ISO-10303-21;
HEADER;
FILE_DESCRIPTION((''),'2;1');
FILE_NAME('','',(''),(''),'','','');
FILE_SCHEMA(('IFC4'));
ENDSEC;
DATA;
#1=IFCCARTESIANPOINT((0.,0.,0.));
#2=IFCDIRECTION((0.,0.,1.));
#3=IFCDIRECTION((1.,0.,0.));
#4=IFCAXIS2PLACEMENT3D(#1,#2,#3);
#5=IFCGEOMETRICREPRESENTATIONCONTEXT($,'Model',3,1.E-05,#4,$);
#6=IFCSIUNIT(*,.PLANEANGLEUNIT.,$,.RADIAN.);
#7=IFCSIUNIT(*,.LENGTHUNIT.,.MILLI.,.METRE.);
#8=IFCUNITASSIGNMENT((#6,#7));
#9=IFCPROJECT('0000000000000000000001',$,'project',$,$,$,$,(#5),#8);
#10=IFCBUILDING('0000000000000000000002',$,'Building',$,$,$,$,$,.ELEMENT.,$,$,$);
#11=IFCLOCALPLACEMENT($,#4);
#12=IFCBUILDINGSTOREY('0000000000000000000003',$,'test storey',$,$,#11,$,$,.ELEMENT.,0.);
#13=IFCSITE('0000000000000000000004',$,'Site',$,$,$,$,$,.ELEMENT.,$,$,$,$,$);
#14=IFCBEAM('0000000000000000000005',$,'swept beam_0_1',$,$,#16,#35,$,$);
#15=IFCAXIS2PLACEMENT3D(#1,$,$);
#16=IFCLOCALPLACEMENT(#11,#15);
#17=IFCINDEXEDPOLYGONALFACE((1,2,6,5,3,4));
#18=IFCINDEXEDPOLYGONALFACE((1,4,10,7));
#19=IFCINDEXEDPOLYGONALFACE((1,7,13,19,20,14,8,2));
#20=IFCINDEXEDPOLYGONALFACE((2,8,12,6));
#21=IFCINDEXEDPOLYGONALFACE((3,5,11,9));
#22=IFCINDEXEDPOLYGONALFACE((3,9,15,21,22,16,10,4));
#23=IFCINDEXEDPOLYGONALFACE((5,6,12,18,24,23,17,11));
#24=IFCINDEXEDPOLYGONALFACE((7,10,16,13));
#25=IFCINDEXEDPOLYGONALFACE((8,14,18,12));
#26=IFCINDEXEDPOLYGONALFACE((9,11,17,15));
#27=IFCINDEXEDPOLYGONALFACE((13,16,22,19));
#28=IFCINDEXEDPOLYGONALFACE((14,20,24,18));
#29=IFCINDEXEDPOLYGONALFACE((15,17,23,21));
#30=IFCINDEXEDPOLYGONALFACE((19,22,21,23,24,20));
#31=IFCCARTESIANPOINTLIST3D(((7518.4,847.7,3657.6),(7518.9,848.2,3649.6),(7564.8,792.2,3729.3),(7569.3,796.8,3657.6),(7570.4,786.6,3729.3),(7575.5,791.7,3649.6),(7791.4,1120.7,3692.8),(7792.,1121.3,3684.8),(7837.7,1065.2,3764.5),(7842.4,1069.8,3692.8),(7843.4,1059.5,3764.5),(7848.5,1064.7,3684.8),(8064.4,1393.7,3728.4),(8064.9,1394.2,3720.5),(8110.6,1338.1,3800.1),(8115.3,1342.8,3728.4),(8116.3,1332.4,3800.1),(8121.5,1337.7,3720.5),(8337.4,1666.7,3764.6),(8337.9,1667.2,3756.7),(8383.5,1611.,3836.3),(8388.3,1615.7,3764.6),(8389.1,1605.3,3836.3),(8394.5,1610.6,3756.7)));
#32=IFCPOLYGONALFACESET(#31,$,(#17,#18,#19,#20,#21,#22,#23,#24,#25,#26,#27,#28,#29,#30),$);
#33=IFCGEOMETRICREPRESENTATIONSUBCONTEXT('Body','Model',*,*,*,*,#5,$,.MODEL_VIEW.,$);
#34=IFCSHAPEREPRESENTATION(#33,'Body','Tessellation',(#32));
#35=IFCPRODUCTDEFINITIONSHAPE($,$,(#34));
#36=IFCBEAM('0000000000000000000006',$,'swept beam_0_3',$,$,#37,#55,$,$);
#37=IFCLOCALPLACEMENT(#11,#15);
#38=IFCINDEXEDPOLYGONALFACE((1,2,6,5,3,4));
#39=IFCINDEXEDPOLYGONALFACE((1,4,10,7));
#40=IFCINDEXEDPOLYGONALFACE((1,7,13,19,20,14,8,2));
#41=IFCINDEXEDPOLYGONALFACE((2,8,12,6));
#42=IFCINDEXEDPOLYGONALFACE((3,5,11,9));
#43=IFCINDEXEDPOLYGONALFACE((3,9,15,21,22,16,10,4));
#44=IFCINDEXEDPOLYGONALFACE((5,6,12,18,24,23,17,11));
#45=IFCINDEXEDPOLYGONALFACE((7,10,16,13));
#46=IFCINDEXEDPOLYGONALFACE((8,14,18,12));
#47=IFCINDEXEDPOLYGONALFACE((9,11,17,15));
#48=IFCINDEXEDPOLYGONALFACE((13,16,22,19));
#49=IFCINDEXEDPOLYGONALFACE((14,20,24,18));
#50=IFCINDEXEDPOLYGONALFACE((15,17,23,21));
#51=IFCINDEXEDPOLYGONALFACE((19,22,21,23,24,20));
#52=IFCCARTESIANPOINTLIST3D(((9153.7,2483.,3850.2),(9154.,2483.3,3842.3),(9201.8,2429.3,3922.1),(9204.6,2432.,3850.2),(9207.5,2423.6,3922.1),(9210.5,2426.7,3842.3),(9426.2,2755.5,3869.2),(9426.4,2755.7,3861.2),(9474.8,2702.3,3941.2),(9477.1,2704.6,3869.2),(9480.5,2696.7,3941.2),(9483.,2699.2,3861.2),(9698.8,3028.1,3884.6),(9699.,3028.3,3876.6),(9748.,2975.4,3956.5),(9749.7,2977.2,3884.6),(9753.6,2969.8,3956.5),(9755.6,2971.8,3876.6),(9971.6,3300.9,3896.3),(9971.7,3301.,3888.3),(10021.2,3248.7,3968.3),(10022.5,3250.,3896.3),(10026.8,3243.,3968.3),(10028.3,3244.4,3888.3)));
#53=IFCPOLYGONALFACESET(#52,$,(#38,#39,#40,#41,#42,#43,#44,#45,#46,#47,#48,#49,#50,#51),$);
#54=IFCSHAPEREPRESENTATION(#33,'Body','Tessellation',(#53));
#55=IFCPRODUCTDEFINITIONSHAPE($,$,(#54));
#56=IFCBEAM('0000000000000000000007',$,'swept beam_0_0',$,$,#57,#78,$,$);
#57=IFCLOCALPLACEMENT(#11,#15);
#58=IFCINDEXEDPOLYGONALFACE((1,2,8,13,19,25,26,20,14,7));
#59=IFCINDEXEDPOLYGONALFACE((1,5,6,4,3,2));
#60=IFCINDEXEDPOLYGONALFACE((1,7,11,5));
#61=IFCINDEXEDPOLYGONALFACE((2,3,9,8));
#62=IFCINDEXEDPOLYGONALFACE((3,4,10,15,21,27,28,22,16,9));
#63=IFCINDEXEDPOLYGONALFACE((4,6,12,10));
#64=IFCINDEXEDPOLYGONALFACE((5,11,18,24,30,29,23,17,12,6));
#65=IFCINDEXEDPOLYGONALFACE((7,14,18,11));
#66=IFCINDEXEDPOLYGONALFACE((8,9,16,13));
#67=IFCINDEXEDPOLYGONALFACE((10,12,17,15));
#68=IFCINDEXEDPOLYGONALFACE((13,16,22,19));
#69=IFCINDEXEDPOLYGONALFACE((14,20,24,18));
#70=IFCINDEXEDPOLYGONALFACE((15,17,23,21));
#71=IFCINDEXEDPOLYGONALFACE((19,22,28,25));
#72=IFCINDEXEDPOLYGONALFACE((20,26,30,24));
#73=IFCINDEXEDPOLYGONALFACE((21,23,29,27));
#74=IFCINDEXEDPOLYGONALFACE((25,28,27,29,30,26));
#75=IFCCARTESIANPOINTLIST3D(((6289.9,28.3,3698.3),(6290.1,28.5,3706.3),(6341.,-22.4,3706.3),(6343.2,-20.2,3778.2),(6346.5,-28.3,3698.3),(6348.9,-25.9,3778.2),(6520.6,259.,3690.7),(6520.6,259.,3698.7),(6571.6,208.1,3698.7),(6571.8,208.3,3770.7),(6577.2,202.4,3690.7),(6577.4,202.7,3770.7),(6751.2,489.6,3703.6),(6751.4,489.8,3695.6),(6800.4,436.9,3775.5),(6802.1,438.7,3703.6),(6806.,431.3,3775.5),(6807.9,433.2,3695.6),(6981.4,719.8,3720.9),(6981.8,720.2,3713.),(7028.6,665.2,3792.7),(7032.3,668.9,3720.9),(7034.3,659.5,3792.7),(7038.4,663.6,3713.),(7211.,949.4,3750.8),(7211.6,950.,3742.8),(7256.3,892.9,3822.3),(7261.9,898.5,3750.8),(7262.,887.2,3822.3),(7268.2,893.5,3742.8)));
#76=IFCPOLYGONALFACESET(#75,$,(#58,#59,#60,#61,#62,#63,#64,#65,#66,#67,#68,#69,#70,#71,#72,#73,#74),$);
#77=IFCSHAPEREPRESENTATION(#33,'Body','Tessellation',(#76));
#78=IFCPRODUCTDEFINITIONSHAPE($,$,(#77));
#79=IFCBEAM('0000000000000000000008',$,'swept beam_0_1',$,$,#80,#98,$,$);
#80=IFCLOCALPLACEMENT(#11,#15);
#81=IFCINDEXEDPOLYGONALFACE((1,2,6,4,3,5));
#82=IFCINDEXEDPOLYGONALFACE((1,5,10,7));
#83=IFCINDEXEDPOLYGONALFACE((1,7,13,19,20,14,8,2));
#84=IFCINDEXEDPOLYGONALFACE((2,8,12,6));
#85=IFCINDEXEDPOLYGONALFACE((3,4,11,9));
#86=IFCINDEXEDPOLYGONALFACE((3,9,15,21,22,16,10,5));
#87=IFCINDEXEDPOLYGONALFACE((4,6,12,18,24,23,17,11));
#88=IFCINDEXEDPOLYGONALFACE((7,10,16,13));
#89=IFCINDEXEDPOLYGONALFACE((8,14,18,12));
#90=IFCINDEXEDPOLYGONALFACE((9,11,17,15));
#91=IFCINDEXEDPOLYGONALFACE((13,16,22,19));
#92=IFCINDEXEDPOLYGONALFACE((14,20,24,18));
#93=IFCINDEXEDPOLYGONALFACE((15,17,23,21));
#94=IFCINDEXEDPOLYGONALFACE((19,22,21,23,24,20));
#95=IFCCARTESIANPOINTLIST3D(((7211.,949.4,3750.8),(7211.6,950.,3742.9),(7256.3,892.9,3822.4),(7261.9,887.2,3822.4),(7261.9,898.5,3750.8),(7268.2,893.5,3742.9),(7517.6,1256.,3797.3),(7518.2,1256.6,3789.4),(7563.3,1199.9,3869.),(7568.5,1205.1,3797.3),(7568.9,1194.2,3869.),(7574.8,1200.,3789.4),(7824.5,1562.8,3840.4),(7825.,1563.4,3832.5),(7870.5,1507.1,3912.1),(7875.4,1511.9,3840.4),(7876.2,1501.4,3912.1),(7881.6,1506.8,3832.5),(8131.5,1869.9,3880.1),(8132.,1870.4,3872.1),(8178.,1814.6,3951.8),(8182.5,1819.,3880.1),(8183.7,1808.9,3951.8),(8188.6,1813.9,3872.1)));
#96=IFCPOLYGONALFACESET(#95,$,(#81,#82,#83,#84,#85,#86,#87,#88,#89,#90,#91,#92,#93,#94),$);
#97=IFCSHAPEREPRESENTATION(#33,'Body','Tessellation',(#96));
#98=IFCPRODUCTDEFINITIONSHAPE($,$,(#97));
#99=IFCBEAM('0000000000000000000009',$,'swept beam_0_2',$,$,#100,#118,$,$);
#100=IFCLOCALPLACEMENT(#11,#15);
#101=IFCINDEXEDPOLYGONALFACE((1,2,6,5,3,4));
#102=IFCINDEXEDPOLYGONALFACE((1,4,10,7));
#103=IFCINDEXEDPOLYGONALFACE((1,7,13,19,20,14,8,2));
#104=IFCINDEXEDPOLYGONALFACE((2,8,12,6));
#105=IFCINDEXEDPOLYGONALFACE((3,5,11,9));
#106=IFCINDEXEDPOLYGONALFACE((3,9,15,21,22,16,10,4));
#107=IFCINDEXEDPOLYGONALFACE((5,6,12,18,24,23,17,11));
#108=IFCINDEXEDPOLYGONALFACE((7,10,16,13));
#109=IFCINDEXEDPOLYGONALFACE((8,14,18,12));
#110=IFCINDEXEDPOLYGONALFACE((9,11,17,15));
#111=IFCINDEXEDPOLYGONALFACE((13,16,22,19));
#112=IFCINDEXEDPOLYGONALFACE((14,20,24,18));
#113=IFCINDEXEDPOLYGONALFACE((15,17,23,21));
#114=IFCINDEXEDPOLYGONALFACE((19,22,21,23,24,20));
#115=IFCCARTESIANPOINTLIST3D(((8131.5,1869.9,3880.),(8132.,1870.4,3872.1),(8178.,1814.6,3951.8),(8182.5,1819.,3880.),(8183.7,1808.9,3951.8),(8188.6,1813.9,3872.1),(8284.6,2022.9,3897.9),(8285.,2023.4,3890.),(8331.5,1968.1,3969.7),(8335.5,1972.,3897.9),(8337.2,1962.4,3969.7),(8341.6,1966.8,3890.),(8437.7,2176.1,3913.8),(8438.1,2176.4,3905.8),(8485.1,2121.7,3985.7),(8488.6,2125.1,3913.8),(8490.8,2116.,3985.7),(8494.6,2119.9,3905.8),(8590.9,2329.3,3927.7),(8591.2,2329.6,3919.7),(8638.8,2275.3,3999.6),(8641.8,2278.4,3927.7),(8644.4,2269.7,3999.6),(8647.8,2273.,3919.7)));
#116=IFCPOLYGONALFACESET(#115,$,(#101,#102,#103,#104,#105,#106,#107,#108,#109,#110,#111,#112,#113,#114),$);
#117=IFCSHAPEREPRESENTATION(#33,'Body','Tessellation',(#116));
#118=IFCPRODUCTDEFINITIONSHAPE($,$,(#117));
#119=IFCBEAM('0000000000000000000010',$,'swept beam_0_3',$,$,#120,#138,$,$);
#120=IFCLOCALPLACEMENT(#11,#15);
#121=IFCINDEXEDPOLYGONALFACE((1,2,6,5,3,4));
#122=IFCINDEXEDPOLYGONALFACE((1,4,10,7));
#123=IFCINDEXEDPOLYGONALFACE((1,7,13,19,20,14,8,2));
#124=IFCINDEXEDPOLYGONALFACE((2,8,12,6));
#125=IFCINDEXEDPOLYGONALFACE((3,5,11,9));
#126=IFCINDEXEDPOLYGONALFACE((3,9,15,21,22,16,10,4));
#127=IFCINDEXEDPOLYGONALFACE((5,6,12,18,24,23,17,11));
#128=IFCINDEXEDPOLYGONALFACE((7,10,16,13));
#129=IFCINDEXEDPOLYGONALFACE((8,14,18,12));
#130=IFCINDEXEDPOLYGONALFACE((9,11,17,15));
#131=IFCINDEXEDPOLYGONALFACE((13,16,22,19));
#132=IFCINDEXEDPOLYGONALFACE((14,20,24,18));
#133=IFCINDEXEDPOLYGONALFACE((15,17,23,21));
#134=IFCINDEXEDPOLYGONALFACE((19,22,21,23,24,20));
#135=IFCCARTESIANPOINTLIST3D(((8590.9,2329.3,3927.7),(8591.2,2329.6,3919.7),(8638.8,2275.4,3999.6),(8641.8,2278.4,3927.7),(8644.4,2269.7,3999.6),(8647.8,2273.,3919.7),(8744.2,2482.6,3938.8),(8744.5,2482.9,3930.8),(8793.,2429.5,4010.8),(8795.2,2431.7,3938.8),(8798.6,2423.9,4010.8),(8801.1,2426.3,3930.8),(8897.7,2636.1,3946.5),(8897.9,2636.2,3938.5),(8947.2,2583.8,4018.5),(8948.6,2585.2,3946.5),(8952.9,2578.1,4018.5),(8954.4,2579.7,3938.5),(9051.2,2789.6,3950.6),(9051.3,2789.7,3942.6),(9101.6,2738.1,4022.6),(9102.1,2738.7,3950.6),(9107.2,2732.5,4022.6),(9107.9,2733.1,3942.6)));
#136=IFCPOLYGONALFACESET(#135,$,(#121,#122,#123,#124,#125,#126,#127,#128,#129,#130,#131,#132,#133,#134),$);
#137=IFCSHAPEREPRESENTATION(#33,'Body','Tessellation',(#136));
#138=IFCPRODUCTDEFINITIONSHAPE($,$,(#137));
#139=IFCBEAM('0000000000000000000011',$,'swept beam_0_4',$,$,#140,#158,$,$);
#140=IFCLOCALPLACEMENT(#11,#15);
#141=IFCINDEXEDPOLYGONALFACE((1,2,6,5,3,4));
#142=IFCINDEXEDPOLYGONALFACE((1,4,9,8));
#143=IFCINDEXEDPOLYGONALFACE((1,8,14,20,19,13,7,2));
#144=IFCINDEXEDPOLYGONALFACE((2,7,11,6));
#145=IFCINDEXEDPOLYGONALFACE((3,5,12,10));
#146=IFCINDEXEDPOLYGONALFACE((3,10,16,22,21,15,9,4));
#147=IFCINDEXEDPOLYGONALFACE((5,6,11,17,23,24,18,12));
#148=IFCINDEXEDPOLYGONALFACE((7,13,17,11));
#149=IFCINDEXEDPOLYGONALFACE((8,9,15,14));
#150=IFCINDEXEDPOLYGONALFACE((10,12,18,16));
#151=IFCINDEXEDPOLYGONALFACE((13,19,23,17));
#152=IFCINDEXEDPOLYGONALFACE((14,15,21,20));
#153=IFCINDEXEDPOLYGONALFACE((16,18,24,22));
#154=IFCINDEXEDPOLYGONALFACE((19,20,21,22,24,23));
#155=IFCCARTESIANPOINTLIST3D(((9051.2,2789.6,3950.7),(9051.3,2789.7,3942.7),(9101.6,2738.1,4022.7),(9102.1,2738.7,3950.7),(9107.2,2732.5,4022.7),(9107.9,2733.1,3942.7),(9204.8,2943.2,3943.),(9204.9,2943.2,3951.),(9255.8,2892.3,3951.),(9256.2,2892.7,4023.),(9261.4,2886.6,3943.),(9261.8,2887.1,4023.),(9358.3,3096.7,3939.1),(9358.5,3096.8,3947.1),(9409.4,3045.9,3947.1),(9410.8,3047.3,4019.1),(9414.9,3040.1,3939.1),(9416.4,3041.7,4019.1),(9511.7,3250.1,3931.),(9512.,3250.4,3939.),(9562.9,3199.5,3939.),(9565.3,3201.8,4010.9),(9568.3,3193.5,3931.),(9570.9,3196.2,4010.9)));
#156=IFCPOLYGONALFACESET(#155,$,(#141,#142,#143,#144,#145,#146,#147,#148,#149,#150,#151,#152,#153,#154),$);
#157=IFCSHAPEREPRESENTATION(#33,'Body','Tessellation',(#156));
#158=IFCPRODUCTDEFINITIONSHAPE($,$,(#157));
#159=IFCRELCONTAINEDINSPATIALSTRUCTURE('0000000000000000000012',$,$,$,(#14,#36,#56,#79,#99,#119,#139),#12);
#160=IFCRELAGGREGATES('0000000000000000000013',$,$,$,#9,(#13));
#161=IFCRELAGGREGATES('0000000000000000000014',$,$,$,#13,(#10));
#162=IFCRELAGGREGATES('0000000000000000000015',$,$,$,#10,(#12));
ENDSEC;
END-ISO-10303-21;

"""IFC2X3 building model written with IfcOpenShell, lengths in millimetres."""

from ifc_helpers import new_model, entity, si_unit, origin_with_axes, place, context, subcontext, project, spatial, element, save


model = new_model("IFC2X3")

# Units and contexts
model_context = context("Model", 3, precision=1e-05, world=origin_with_axes())
body_context = subcontext(model_context, "Body", "Model", "MODEL_VIEW")
ifc_project = project(units=[si_unit("PLANEANGLEUNIT", "RADIAN"), si_unit("LENGTHUNIT", "METRE", prefix="MILLI")], contexts=[model_context])

# Site, building, storey
site = spatial("IfcSite", under=ifc_project, Name="Site", CompositionType="ELEMENT")
building = spatial("IfcBuilding", under=site, Name="Building", CompositionType="ELEMENT")
storey_placement = place(None, origin_with_axes())
storey = spatial("IfcBuildingStorey", under=building, at=storey_placement, Name="test storey", CompositionType="ELEMENT", Elevation=0.0)

# Beams
beam_1_placement = place(storey_placement, origin_with_axes())
element("IfcBeam", 1, at=beam_1_placement, inside=storey, Name="swept beam_0_1", context=body_context, shape_type="SweptSolid", body=[
    entity("IfcRevolvedAreaSolid", entity("IfcArbitraryClosedProfileDef", "AREA", None, entity("IfcPolyline", [entity("IfcCartesianPoint", [-80.0, 40.0]), entity("IfcCartesianPoint", [-80.0, 32.0]), entity("IfcCartesianPoint", [-8.0, 32.0]), entity("IfcCartesianPoint", [-8.0, -40.0]), entity("IfcCartesianPoint", [0.0, -40.0]), entity("IfcCartesianPoint", [0.0, 40.0]), entity("IfcCartesianPoint", [-80.0, 40.0])])), entity("IfcAxis2Placement3D", entity("IfcCartesianPoint", [7547.2, 820.0, 3649.6]), entity("IfcDirection", [-0.7042, -0.7042, -0.09]), entity("IfcDirection", [0.0636, 0.0636, -0.9959])), entity("IfcAxis1Placement", entity("IfcCartesianPoint", [-287616.3, 0.0, 0.0]), entity("IfcDirection", [0.0, 1.0, 0.0])), 0.004044),
])
beam_2_placement = place(storey_placement, origin_with_axes())
element("IfcBeam", 2, at=beam_2_placement, inside=storey, Name="swept beam_0_3", context=body_context, shape_type="SweptSolid", body=[
    entity("IfcRevolvedAreaSolid", entity("IfcArbitraryClosedProfileDef", "AREA", None, entity("IfcPolyline", [entity("IfcCartesianPoint", [80.0, -40.0]), entity("IfcCartesianPoint", [80.0, -32.0]), entity("IfcCartesianPoint", [8.0, -32.0]), entity("IfcCartesianPoint", [8.0, 40.0]), entity("IfcCartesianPoint", [0.0, 40.0]), entity("IfcCartesianPoint", [0.0, -40.0]), entity("IfcCartesianPoint", [80.0, -40.0])])), entity("IfcAxis2Placement3D", entity("IfcCartesianPoint", [9182.2, 2455.0, 3842.3]), entity("IfcDirection", [-0.7061, -0.7061, -0.0539]), entity("IfcDirection", [-0.0381, -0.0381, 0.9985])), entity("IfcAxis1Placement", entity("IfcCartesianPoint", [-40917.4, 0.0, 0.0]), entity("IfcDirection", [0.0, 1.0, 0.0])), 0.028287),
])
beam_3_placement = place(storey_placement, origin_with_axes())
element("IfcBeam", 3, at=beam_3_placement, inside=storey, Name="swept beam_0_0", context=body_context, shape_type="SweptSolid", body=[
    entity("IfcRevolvedAreaSolid", entity("IfcArbitraryClosedProfileDef", "AREA", None, entity("IfcPolyline", [entity("IfcCartesianPoint", [-80.0, 40.0]), entity("IfcCartesianPoint", [-80.0, 32.0]), entity("IfcCartesianPoint", [-8.0, 32.0]), entity("IfcCartesianPoint", [-8.0, -40.0]), entity("IfcCartesianPoint", [0.0, -40.0]), entity("IfcCartesianPoint", [0.0, 40.0]), entity("IfcCartesianPoint", [-80.0, 40.0])])), entity("IfcAxis2Placement3D", entity("IfcCartesianPoint", [6318.2, 0.0, 3698.3]), entity("IfcDirection", [-0.7065, -0.7065, 0.0425]), entity("IfcDirection", [-0.03, -0.03, -0.9991])), entity("IfcAxis1Placement", entity("IfcCartesianPoint", [-8518.9, 0.0, 0.0]), entity("IfcDirection", [0.0, 1.0, 0.0])), 0.153256),
])
beam_4_placement = place(storey_placement, origin_with_axes())
element("IfcBeam", 4, at=beam_4_placement, inside=storey, Name="swept beam_0_1", context=body_context, shape_type="SweptSolid", body=[
    entity("IfcRevolvedAreaSolid", entity("IfcArbitraryClosedProfileDef", "AREA", None, entity("IfcPolyline", [entity("IfcCartesianPoint", [80.0, -40.0]), entity("IfcCartesianPoint", [80.0, -32.0]), entity("IfcCartesianPoint", [8.0, -32.0]), entity("IfcCartesianPoint", [8.0, 40.0]), entity("IfcCartesianPoint", [0.0, 40.0]), entity("IfcCartesianPoint", [0.0, -40.0]), entity("IfcCartesianPoint", [80.0, -40.0])])), entity("IfcAxis2Placement3D", entity("IfcCartesianPoint", [7239.9, 921.7, 3742.9]), entity("IfcDirection", [-0.7028, -0.7028, -0.1106]), entity("IfcDirection", [-0.0782, -0.0782, 0.9939])), entity("IfcAxis1Placement", entity("IfcCartesianPoint", [-55201.6, 0.0, 0.0]), entity("IfcDirection", [0.0, 1.0, 0.0])), 0.023696),
])
beam_5_placement = place(storey_placement, origin_with_axes())
element("IfcBeam", 5, at=beam_5_placement, inside=storey, Name="swept beam_0_2", context=body_context, shape_type="SweptSolid", body=[
    entity("IfcRevolvedAreaSolid", entity("IfcArbitraryClosedProfileDef", "AREA", None, entity("IfcPolyline", [entity("IfcCartesianPoint", [80.0, -40.0]), entity("IfcCartesianPoint", [80.0, -32.0]), entity("IfcCartesianPoint", [8.0, -32.0]), entity("IfcCartesianPoint", [8.0, 40.0]), entity("IfcCartesianPoint", [0.0, 40.0]), entity("IfcCartesianPoint", [0.0, -40.0]), entity("IfcCartesianPoint", [80.0, -40.0])])), entity("IfcAxis2Placement3D", entity("IfcCartesianPoint", [8160.3, 1842.1, 3872.1]), entity("IfcDirection", [-0.7044, -0.7044, -0.087]), entity("IfcDirection", [-0.0615, -0.0615, 0.9962])), entity("IfcAxis1Placement", entity("IfcCartesianPoint", [-23477.9, 0.0, 0.0]), entity("IfcDirection", [0.0, 1.0, 0.0])), 0.027735),
])
beam_6_placement = place(storey_placement, origin_with_axes())
element("IfcBeam", 6, at=beam_6_placement, inside=storey, Name="swept beam_0_3", context=body_context, shape_type="SweptSolid", body=[
    entity("IfcRevolvedAreaSolid", entity("IfcArbitraryClosedProfileDef", "AREA", None, entity("IfcPolyline", [entity("IfcCartesianPoint", [80.0, -40.0]), entity("IfcCartesianPoint", [80.0, -32.0]), entity("IfcCartesianPoint", [8.0, -32.0]), entity("IfcCartesianPoint", [8.0, 40.0]), entity("IfcCartesianPoint", [0.0, 40.0]), entity("IfcCartesianPoint", [0.0, -40.0]), entity("IfcCartesianPoint", [80.0, -40.0])])), entity("IfcAxis2Placement3D", entity("IfcCartesianPoint", [8619.5, 2301.3, 3919.7]), entity("IfcDirection", [-0.7059, -0.7059, -0.0593]), entity("IfcDirection", [-0.0419, -0.0419, 0.9982])), entity("IfcAxis1Placement", entity("IfcCartesianPoint", [-13498.6, 0.0, 0.0]), entity("IfcDirection", [0.0, 1.0, 0.0])), 0.048233),
])
beam_7_placement = place(storey_placement, origin_with_axes())
element("IfcBeam", 7, at=beam_7_placement, inside=storey, Name="swept beam_0_4", context=body_context, shape_type="SweptSolid", body=[
    entity("IfcRevolvedAreaSolid", entity("IfcArbitraryClosedProfileDef", "AREA", None, entity("IfcPolyline", [entity("IfcCartesianPoint", [80.0, -40.0]), entity("IfcCartesianPoint", [80.0, -32.0]), entity("IfcCartesianPoint", [8.0, -32.0]), entity("IfcCartesianPoint", [8.0, 40.0]), entity("IfcCartesianPoint", [0.0, 40.0]), entity("IfcCartesianPoint", [0.0, -40.0]), entity("IfcCartesianPoint", [80.0, -40.0])])), entity("IfcAxis2Placement3D", entity("IfcCartesianPoint", [9079.6, 2761.4, 3942.7]), entity("IfcDirection", [-0.7071, -0.7071, -0.0111]), entity("IfcDirection", [-0.0079, -0.0079, 0.9999])), entity("IfcAxis1Placement", entity("IfcCartesianPoint", [-11229.8, 0.0, 0.0]), entity("IfcDirection", [0.0, 1.0, 0.0])), 0.058002),
])

save(model, "model.ifc")
